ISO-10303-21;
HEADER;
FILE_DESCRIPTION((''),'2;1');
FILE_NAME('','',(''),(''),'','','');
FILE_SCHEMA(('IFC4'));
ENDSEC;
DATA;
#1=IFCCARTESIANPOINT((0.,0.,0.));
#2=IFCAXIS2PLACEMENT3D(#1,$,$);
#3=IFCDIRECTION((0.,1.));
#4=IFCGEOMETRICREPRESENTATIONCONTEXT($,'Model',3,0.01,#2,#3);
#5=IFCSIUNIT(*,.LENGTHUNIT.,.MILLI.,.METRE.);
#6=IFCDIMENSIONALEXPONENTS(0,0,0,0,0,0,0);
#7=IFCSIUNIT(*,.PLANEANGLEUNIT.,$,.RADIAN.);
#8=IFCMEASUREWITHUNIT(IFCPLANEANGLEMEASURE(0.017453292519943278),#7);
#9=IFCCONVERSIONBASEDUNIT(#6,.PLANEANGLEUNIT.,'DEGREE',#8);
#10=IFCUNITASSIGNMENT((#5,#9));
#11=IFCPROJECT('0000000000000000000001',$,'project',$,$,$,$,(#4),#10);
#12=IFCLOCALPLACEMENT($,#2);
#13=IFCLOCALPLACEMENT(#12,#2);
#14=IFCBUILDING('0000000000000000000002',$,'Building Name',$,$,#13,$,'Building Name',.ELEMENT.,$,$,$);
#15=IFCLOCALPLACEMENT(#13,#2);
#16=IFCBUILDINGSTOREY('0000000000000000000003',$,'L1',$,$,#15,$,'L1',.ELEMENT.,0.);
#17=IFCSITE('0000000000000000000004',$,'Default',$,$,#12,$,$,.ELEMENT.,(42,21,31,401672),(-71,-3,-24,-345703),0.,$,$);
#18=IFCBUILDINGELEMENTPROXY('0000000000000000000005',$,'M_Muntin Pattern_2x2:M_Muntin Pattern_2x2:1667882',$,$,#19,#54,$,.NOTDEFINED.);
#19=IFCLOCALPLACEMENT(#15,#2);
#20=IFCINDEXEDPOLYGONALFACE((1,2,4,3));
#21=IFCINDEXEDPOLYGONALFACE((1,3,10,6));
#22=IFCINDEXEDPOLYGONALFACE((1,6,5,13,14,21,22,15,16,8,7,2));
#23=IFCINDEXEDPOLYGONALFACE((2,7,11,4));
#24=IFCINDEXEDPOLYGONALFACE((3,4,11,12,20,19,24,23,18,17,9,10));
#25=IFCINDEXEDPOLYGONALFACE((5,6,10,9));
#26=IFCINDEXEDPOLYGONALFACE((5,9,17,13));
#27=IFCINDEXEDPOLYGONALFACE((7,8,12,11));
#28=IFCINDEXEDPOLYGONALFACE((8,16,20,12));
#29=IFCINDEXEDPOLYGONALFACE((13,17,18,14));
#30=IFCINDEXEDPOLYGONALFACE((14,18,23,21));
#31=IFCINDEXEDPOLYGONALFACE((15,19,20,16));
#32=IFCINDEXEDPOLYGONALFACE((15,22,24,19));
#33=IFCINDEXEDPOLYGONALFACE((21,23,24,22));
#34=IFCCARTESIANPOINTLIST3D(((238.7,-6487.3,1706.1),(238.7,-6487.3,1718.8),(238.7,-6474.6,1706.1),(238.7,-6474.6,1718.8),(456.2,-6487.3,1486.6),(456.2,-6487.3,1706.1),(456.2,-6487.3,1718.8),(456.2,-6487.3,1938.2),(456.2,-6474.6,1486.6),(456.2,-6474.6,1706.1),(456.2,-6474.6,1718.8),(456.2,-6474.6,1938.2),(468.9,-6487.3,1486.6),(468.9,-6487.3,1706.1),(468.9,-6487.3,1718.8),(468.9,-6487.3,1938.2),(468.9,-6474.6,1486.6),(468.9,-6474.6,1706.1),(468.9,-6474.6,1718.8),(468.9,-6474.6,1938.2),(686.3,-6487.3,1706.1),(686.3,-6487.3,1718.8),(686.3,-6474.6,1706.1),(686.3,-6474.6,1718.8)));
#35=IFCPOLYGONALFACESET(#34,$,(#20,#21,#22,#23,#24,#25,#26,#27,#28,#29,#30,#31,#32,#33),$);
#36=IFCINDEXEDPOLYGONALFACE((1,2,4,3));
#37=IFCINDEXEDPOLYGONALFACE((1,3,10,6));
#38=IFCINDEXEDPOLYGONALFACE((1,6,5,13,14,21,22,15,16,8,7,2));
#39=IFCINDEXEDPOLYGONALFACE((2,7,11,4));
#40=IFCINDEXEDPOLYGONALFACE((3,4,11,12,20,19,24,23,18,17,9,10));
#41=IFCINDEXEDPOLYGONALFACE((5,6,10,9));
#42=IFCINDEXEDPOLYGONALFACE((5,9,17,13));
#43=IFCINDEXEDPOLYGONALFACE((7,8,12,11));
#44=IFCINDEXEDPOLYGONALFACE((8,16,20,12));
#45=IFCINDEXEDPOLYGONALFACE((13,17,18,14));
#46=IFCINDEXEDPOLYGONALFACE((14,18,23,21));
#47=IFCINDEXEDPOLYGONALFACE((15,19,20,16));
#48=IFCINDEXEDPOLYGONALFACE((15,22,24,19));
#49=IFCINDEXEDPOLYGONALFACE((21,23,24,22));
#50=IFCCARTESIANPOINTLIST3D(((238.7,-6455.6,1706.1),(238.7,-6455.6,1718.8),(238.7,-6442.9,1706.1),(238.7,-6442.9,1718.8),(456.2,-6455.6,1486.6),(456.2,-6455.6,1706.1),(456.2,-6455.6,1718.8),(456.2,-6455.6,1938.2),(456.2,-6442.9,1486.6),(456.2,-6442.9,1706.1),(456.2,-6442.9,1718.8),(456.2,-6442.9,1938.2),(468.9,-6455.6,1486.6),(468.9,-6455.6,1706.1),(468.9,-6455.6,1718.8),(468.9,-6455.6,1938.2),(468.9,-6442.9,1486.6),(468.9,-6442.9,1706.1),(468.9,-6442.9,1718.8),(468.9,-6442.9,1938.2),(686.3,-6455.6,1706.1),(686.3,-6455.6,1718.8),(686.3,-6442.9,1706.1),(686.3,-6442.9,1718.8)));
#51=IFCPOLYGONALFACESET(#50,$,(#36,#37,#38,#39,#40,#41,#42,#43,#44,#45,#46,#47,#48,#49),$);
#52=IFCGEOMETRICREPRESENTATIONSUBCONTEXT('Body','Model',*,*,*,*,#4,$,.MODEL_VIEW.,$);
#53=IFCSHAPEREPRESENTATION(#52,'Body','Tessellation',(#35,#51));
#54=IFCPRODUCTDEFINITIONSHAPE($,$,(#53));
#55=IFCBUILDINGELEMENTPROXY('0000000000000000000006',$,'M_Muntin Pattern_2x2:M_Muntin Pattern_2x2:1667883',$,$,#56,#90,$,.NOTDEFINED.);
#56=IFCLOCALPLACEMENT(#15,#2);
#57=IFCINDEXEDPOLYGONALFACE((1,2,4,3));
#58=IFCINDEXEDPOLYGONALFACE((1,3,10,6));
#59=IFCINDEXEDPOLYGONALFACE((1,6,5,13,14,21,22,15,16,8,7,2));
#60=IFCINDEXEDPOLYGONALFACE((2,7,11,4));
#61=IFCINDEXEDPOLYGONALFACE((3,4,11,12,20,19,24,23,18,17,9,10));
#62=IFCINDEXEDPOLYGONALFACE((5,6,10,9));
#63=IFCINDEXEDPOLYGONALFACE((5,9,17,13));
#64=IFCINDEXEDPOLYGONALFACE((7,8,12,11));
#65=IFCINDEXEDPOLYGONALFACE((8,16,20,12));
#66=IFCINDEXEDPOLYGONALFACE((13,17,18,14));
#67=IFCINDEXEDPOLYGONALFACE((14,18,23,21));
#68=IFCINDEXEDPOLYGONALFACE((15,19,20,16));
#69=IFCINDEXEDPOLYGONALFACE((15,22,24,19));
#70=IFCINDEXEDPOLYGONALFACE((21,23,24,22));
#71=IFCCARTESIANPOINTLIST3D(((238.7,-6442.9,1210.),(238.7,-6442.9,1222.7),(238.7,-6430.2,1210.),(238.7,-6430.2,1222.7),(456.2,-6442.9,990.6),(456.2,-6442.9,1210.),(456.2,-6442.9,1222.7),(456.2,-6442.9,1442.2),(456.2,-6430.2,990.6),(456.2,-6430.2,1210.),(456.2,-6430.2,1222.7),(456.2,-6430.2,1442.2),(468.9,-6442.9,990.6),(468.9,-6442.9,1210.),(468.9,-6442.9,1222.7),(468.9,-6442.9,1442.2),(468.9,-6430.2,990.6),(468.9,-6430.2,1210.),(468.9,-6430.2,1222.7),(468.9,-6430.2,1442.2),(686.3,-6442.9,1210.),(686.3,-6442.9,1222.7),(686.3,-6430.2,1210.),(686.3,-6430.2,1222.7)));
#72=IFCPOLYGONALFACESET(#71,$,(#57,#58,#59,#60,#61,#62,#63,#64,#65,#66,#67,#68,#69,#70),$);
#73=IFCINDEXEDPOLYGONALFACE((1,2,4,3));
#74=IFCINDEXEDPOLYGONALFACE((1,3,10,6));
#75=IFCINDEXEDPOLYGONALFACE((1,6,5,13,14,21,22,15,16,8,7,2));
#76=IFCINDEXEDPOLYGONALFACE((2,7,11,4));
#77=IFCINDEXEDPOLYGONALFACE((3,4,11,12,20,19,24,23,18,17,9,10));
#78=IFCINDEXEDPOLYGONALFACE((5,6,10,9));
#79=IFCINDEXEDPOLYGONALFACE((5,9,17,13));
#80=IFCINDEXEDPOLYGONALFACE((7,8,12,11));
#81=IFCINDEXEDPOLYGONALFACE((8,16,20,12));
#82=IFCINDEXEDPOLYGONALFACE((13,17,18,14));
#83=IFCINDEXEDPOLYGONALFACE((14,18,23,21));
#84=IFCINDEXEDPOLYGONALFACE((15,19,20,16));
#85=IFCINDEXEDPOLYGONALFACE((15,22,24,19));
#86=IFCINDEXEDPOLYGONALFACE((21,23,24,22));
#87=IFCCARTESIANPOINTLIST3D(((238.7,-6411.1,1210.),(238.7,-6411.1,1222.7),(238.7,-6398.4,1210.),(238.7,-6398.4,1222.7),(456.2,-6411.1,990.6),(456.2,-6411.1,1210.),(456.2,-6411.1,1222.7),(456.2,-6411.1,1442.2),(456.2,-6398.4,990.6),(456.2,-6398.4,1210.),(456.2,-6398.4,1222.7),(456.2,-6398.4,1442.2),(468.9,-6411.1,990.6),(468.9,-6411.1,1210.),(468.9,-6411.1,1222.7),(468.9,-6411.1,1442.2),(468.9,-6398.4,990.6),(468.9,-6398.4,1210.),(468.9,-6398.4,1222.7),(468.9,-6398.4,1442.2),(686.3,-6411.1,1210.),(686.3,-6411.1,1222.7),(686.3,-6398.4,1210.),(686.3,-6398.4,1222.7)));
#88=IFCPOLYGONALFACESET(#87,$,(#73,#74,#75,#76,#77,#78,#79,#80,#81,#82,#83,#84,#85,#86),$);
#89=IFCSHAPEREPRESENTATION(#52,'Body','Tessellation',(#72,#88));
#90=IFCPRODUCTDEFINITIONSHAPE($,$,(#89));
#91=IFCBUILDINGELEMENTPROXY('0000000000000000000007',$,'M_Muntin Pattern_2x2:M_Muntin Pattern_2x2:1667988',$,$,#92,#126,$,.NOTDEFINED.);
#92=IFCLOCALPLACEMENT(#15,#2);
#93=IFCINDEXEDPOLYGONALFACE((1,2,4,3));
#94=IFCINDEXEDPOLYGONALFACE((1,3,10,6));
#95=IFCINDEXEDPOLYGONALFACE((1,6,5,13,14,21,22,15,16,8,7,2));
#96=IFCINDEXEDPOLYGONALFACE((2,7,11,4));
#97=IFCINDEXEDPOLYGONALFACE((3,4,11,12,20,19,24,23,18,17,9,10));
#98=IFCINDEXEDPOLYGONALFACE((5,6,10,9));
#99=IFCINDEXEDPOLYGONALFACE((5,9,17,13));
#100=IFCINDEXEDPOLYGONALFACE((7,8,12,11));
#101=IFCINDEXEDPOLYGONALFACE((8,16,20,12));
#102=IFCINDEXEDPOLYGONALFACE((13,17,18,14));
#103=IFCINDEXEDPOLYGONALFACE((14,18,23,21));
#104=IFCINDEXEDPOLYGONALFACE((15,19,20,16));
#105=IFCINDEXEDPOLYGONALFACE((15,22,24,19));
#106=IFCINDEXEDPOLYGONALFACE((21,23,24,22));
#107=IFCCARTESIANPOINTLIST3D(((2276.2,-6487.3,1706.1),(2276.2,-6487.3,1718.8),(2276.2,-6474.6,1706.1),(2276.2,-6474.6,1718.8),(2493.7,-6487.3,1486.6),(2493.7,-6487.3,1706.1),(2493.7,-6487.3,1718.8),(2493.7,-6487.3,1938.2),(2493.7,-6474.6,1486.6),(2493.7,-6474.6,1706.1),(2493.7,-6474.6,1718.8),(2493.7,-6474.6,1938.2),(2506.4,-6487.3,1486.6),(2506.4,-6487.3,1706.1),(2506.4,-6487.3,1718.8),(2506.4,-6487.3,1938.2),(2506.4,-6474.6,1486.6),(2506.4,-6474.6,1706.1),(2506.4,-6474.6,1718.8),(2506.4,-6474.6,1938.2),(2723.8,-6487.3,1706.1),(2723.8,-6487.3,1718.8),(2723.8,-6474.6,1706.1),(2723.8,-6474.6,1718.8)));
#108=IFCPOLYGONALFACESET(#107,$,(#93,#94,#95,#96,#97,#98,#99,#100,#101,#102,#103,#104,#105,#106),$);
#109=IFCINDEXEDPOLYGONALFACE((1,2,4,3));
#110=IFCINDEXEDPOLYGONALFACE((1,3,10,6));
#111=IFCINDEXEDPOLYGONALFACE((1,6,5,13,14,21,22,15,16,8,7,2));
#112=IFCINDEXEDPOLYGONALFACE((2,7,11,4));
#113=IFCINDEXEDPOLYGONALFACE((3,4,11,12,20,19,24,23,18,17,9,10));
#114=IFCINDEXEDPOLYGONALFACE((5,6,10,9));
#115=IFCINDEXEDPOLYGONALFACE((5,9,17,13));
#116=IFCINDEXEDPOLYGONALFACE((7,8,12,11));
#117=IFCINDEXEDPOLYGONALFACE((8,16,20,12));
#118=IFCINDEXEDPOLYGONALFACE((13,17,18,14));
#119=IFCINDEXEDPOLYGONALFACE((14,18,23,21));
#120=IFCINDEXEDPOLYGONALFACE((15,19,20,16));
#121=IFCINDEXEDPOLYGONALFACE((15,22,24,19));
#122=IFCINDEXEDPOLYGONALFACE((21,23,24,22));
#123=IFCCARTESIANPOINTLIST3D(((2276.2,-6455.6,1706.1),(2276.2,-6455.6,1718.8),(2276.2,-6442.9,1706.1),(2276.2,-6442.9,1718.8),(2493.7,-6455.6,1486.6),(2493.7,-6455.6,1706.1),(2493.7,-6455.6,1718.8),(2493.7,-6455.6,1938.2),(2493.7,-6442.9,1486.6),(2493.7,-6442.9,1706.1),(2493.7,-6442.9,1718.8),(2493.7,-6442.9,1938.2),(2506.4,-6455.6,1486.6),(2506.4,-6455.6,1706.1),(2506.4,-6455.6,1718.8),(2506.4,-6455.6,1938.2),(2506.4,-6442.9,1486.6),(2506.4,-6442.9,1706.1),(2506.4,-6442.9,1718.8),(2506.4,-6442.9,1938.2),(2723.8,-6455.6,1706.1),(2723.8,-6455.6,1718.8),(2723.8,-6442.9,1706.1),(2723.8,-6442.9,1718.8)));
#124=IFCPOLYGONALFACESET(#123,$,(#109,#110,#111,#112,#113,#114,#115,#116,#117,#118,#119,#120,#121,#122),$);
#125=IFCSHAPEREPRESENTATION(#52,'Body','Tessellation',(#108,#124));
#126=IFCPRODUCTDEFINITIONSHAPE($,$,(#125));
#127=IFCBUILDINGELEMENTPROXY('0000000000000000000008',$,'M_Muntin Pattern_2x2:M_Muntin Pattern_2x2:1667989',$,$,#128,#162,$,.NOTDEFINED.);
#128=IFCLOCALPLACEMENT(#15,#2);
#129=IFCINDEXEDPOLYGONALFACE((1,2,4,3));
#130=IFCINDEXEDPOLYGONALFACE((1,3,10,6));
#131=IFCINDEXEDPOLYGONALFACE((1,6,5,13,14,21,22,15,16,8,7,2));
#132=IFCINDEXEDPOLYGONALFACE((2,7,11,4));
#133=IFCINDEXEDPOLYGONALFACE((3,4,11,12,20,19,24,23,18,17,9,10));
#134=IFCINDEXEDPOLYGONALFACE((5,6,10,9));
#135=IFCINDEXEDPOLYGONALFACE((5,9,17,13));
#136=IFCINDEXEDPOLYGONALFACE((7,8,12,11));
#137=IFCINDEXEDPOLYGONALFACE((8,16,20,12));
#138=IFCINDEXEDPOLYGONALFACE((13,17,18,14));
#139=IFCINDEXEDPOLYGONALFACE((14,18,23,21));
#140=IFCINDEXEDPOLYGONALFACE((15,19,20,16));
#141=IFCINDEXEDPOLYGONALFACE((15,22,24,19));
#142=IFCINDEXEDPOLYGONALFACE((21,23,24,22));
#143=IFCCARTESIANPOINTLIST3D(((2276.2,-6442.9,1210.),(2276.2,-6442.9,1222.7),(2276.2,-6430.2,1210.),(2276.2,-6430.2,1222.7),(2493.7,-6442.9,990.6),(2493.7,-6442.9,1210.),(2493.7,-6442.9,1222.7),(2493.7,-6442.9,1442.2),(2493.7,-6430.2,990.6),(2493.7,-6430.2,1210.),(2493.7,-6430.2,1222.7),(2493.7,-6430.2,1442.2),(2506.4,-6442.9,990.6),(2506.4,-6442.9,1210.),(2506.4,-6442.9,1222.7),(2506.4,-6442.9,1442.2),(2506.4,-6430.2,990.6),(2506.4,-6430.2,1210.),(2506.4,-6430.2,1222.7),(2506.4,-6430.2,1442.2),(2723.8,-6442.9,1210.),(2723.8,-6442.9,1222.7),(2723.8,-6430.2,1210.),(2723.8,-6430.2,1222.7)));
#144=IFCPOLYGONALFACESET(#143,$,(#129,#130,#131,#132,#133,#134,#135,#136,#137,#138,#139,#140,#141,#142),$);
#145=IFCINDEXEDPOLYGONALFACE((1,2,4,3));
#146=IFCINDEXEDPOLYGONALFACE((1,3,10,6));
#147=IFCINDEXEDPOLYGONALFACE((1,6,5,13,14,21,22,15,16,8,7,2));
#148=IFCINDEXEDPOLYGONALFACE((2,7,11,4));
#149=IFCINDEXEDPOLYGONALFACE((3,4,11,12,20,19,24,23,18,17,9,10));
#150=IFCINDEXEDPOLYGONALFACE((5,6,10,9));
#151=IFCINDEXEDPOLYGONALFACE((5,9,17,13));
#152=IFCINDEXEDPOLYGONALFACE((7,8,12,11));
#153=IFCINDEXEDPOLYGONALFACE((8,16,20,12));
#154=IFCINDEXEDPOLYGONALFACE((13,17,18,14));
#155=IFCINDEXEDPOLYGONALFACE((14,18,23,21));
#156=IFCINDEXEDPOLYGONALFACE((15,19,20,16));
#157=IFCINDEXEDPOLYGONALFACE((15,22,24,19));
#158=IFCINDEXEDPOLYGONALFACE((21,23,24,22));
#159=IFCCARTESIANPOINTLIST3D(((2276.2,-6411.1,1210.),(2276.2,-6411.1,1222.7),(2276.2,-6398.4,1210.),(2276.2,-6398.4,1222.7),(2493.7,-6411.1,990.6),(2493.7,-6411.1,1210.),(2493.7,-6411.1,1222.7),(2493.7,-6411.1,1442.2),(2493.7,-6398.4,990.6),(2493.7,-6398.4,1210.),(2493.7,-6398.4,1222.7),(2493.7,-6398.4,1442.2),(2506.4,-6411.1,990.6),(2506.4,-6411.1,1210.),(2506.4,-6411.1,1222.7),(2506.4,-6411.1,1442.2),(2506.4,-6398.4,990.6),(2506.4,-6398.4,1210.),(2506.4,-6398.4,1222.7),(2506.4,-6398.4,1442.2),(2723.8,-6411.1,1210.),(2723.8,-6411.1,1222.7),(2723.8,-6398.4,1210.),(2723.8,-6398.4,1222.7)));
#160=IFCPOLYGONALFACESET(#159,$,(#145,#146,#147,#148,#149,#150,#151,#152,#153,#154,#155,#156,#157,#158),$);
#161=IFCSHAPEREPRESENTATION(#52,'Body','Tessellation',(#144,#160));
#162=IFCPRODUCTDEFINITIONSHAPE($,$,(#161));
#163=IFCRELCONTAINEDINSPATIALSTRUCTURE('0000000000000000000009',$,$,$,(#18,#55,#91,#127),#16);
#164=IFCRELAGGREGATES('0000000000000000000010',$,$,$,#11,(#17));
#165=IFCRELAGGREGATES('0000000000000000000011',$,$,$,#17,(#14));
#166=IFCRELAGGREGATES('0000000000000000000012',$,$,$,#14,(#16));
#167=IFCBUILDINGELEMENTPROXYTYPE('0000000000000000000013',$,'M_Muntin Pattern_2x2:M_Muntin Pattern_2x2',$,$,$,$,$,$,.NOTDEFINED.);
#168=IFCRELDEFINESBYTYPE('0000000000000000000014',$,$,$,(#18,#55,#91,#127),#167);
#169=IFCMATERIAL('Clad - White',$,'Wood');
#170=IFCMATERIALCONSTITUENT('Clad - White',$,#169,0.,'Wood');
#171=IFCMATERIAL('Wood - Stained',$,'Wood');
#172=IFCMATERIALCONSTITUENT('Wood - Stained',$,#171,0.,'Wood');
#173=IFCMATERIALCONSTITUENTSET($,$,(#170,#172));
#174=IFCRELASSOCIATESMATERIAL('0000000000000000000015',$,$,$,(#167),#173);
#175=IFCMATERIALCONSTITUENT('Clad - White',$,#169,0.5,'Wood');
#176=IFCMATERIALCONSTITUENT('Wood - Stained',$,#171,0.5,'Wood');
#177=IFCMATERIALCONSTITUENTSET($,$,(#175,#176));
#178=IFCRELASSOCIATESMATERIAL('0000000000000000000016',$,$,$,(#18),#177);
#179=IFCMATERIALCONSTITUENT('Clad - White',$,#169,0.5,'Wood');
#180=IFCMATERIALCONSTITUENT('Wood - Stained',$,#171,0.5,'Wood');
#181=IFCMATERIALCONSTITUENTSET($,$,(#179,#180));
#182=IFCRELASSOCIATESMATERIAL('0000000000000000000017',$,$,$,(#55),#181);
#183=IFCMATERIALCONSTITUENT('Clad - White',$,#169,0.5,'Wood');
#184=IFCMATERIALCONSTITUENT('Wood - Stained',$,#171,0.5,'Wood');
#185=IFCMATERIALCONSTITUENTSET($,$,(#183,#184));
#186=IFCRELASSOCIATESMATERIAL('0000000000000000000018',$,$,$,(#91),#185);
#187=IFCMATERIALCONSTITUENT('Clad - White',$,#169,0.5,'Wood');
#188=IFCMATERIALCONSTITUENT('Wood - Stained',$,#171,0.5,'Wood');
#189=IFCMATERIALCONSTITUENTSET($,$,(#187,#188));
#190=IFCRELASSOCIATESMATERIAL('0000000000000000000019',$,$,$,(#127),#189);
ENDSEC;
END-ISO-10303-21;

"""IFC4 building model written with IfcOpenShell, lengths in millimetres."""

from ifc_helpers import new_model, entity, si_unit, converted_unit, direction, frame, origin, place, context, subcontext, project, spatial, indexed_curve, outline, extrude, source, transform, mapped, material, constituent, constituent_set, type_object, type_shapes, element, save


model = new_model("IFC4")

# Units and contexts
model_context = context("Model", 3, precision=0.01, world=origin(), true_north=direction((0.0, 1.0)))
body_context = subcontext(model_context, "Body", "Model", "MODEL_VIEW")
ifc_project = project(units=[si_unit("LENGTHUNIT", "METRE", prefix="MILLI"), converted_unit("PLANEANGLEUNIT", "DEGREE", entity("IfcPlaneAngleMeasure", 0.017453292519943278), si_unit("PLANEANGLEUNIT", "RADIAN"), dimensions=[0, 0, 0, 0, 0, 0, 0])], contexts=[model_context])

# Site, building, storey
site_placement = place(None, origin())
site = spatial("IfcSite", under=ifc_project, at=site_placement, Name="Default", CompositionType="ELEMENT", RefLatitude=(42, 21, 31, 401672), RefLongitude=(-71, -3, -24, -345703), RefElevation=0.0)
building_placement = place(site_placement, origin())
building = spatial("IfcBuilding", under=site, at=building_placement, Name="Building Name", LongName="Building Name", CompositionType="ELEMENT")
storey_placement = place(building_placement, origin())
storey = spatial("IfcBuildingStorey", under=building, at=storey_placement, Name="L1", LongName="L1", CompositionType="ELEMENT", Elevation=0.0)

# Building element proxies
ifc_material_1 = material(Name="Clad - White", Category="Wood")
ifc_material_2 = material(Name="Wood - Stained", Category="Wood")
ifc_constituent_1 = constituent(ifc_material_1, Name="Clad - White", Category="Wood", fraction=0.0)
ifc_constituent_2 = constituent(ifc_material_2, Name="Wood - Stained", Category="Wood", fraction=0.0)
ifc_constituent_set_1 = constituent_set(constituents=[ifc_constituent_1, ifc_constituent_2])
building_element_proxy_type_1 = type_object("IfcBuildingElementProxyType", Name="M_Muntin Pattern_2x2:M_Muntin Pattern_2x2", PredefinedType="NOTDEFINED", material=ifc_constituent_set_1)
shared_shape_1 = source(origin(), body_context, "Body", "SweptSolid", [
    extrude(outline(indexed_curve([(6.4, -6.4), (225.8, -6.4), (225.8, 6.3), (6.4, 6.3), (6.4, 223.8), (-6.3, 223.8), (-6.3, 6.3), (-225.8, 6.3), (-225.8, -6.4), (-6.3, -6.4), (-6.3, -223.8), (6.4, -223.8), (6.4, -6.4)], self_intersect=False)), frame((0.0, 9.5, 225.8), z_axis=(0.0, 1.0, 0.0), x_axis=(0.0, 0.0, 1.0)), (0.0, 0.0, 1.0), 12.7),
    extrude(outline(indexed_curve([(6.4, -6.4), (225.8, -6.4), (225.8, 6.3), (6.4, 6.3), (6.4, 223.8), (-6.3, 223.8), (-6.3, 6.3), (-225.8, 6.3), (-225.8, -6.4), (-6.3, -6.4), (-6.3, -223.8), (6.4, -223.8), (6.4, -6.4)], self_intersect=False)), frame((0.0, -22.2, 225.8), z_axis=(0.0, 1.0, 0.0), x_axis=(0.0, 0.0, 1.0)), (0.0, 0.0, 1.0), 12.7),
])
type_shapes(building_element_proxy_type_1, [shared_shape_1])
ifc_constituent_3 = constituent(ifc_material_1, Name="Clad - White", Category="Wood", fraction=0.5)
ifc_constituent_4 = constituent(ifc_material_2, Name="Wood - Stained", Category="Wood", fraction=0.5)
ifc_constituent_set_2 = constituent_set(constituents=[ifc_constituent_3, ifc_constituent_4])
proxy_1_placement = place(storey_placement, frame((462.5, -6465.1, 1486.6), z_axis=(0.0, 0.0, 1.0), x_axis=(-1.0, 0.0, 0.0)))
element("IfcBuildingElementProxy", 1, at=proxy_1_placement, inside=storey, type_object=building_element_proxy_type_1, material=ifc_constituent_set_2, Name="M_Muntin Pattern_2x2:M_Muntin Pattern_2x2:1667882", PredefinedType="NOTDEFINED", context=body_context, shape_type="MappedRepresentation", body=[
    mapped(shared_shape_1, transform((0.0, 0.0, 0.0), scale=1.0)),
])
ifc_constituent_5 = constituent(ifc_material_1, Name="Clad - White", Category="Wood", fraction=0.5)
ifc_constituent_6 = constituent(ifc_material_2, Name="Wood - Stained", Category="Wood", fraction=0.5)
ifc_constituent_set_3 = constituent_set(constituents=[ifc_constituent_5, ifc_constituent_6])
proxy_2_placement = place(storey_placement, frame((462.5, -6420.6, 990.6), z_axis=(0.0, 0.0, 1.0), x_axis=(-1.0, 0.0, 0.0)))
element("IfcBuildingElementProxy", 2, at=proxy_2_placement, inside=storey, type_object=building_element_proxy_type_1, material=ifc_constituent_set_3, Name="M_Muntin Pattern_2x2:M_Muntin Pattern_2x2:1667883", PredefinedType="NOTDEFINED", context=body_context, shape_type="MappedRepresentation", body=[
    mapped(shared_shape_1, transform((0.0, 0.0, 0.0), scale=1.0)),
])
ifc_constituent_7 = constituent(ifc_material_1, Name="Clad - White", Category="Wood", fraction=0.5)
ifc_constituent_8 = constituent(ifc_material_2, Name="Wood - Stained", Category="Wood", fraction=0.5)
ifc_constituent_set_4 = constituent_set(constituents=[ifc_constituent_7, ifc_constituent_8])
proxy_3_placement = place(storey_placement, frame((2500.0, -6465.1, 1486.6), z_axis=(0.0, 0.0, 1.0), x_axis=(-1.0, 0.0, 0.0)))
element("IfcBuildingElementProxy", 3, at=proxy_3_placement, inside=storey, type_object=building_element_proxy_type_1, material=ifc_constituent_set_4, Name="M_Muntin Pattern_2x2:M_Muntin Pattern_2x2:1667988", PredefinedType="NOTDEFINED", context=body_context, shape_type="MappedRepresentation", body=[
    mapped(shared_shape_1, transform((0.0, 0.0, 0.0), scale=1.0)),
])
ifc_constituent_9 = constituent(ifc_material_1, Name="Clad - White", Category="Wood", fraction=0.5)
ifc_constituent_10 = constituent(ifc_material_2, Name="Wood - Stained", Category="Wood", fraction=0.5)
ifc_constituent_set_5 = constituent_set(constituents=[ifc_constituent_9, ifc_constituent_10])
proxy_4_placement = place(storey_placement, frame((2500.0, -6420.6, 990.6), z_axis=(0.0, 0.0, 1.0), x_axis=(-1.0, 0.0, 0.0)))
element("IfcBuildingElementProxy", 4, at=proxy_4_placement, inside=storey, type_object=building_element_proxy_type_1, material=ifc_constituent_set_5, Name="M_Muntin Pattern_2x2:M_Muntin Pattern_2x2:1667989", PredefinedType="NOTDEFINED", context=body_context, shape_type="MappedRepresentation", body=[
    mapped(shared_shape_1, transform((0.0, 0.0, 0.0), scale=1.0)),
])

save(model, "model.ifc")
